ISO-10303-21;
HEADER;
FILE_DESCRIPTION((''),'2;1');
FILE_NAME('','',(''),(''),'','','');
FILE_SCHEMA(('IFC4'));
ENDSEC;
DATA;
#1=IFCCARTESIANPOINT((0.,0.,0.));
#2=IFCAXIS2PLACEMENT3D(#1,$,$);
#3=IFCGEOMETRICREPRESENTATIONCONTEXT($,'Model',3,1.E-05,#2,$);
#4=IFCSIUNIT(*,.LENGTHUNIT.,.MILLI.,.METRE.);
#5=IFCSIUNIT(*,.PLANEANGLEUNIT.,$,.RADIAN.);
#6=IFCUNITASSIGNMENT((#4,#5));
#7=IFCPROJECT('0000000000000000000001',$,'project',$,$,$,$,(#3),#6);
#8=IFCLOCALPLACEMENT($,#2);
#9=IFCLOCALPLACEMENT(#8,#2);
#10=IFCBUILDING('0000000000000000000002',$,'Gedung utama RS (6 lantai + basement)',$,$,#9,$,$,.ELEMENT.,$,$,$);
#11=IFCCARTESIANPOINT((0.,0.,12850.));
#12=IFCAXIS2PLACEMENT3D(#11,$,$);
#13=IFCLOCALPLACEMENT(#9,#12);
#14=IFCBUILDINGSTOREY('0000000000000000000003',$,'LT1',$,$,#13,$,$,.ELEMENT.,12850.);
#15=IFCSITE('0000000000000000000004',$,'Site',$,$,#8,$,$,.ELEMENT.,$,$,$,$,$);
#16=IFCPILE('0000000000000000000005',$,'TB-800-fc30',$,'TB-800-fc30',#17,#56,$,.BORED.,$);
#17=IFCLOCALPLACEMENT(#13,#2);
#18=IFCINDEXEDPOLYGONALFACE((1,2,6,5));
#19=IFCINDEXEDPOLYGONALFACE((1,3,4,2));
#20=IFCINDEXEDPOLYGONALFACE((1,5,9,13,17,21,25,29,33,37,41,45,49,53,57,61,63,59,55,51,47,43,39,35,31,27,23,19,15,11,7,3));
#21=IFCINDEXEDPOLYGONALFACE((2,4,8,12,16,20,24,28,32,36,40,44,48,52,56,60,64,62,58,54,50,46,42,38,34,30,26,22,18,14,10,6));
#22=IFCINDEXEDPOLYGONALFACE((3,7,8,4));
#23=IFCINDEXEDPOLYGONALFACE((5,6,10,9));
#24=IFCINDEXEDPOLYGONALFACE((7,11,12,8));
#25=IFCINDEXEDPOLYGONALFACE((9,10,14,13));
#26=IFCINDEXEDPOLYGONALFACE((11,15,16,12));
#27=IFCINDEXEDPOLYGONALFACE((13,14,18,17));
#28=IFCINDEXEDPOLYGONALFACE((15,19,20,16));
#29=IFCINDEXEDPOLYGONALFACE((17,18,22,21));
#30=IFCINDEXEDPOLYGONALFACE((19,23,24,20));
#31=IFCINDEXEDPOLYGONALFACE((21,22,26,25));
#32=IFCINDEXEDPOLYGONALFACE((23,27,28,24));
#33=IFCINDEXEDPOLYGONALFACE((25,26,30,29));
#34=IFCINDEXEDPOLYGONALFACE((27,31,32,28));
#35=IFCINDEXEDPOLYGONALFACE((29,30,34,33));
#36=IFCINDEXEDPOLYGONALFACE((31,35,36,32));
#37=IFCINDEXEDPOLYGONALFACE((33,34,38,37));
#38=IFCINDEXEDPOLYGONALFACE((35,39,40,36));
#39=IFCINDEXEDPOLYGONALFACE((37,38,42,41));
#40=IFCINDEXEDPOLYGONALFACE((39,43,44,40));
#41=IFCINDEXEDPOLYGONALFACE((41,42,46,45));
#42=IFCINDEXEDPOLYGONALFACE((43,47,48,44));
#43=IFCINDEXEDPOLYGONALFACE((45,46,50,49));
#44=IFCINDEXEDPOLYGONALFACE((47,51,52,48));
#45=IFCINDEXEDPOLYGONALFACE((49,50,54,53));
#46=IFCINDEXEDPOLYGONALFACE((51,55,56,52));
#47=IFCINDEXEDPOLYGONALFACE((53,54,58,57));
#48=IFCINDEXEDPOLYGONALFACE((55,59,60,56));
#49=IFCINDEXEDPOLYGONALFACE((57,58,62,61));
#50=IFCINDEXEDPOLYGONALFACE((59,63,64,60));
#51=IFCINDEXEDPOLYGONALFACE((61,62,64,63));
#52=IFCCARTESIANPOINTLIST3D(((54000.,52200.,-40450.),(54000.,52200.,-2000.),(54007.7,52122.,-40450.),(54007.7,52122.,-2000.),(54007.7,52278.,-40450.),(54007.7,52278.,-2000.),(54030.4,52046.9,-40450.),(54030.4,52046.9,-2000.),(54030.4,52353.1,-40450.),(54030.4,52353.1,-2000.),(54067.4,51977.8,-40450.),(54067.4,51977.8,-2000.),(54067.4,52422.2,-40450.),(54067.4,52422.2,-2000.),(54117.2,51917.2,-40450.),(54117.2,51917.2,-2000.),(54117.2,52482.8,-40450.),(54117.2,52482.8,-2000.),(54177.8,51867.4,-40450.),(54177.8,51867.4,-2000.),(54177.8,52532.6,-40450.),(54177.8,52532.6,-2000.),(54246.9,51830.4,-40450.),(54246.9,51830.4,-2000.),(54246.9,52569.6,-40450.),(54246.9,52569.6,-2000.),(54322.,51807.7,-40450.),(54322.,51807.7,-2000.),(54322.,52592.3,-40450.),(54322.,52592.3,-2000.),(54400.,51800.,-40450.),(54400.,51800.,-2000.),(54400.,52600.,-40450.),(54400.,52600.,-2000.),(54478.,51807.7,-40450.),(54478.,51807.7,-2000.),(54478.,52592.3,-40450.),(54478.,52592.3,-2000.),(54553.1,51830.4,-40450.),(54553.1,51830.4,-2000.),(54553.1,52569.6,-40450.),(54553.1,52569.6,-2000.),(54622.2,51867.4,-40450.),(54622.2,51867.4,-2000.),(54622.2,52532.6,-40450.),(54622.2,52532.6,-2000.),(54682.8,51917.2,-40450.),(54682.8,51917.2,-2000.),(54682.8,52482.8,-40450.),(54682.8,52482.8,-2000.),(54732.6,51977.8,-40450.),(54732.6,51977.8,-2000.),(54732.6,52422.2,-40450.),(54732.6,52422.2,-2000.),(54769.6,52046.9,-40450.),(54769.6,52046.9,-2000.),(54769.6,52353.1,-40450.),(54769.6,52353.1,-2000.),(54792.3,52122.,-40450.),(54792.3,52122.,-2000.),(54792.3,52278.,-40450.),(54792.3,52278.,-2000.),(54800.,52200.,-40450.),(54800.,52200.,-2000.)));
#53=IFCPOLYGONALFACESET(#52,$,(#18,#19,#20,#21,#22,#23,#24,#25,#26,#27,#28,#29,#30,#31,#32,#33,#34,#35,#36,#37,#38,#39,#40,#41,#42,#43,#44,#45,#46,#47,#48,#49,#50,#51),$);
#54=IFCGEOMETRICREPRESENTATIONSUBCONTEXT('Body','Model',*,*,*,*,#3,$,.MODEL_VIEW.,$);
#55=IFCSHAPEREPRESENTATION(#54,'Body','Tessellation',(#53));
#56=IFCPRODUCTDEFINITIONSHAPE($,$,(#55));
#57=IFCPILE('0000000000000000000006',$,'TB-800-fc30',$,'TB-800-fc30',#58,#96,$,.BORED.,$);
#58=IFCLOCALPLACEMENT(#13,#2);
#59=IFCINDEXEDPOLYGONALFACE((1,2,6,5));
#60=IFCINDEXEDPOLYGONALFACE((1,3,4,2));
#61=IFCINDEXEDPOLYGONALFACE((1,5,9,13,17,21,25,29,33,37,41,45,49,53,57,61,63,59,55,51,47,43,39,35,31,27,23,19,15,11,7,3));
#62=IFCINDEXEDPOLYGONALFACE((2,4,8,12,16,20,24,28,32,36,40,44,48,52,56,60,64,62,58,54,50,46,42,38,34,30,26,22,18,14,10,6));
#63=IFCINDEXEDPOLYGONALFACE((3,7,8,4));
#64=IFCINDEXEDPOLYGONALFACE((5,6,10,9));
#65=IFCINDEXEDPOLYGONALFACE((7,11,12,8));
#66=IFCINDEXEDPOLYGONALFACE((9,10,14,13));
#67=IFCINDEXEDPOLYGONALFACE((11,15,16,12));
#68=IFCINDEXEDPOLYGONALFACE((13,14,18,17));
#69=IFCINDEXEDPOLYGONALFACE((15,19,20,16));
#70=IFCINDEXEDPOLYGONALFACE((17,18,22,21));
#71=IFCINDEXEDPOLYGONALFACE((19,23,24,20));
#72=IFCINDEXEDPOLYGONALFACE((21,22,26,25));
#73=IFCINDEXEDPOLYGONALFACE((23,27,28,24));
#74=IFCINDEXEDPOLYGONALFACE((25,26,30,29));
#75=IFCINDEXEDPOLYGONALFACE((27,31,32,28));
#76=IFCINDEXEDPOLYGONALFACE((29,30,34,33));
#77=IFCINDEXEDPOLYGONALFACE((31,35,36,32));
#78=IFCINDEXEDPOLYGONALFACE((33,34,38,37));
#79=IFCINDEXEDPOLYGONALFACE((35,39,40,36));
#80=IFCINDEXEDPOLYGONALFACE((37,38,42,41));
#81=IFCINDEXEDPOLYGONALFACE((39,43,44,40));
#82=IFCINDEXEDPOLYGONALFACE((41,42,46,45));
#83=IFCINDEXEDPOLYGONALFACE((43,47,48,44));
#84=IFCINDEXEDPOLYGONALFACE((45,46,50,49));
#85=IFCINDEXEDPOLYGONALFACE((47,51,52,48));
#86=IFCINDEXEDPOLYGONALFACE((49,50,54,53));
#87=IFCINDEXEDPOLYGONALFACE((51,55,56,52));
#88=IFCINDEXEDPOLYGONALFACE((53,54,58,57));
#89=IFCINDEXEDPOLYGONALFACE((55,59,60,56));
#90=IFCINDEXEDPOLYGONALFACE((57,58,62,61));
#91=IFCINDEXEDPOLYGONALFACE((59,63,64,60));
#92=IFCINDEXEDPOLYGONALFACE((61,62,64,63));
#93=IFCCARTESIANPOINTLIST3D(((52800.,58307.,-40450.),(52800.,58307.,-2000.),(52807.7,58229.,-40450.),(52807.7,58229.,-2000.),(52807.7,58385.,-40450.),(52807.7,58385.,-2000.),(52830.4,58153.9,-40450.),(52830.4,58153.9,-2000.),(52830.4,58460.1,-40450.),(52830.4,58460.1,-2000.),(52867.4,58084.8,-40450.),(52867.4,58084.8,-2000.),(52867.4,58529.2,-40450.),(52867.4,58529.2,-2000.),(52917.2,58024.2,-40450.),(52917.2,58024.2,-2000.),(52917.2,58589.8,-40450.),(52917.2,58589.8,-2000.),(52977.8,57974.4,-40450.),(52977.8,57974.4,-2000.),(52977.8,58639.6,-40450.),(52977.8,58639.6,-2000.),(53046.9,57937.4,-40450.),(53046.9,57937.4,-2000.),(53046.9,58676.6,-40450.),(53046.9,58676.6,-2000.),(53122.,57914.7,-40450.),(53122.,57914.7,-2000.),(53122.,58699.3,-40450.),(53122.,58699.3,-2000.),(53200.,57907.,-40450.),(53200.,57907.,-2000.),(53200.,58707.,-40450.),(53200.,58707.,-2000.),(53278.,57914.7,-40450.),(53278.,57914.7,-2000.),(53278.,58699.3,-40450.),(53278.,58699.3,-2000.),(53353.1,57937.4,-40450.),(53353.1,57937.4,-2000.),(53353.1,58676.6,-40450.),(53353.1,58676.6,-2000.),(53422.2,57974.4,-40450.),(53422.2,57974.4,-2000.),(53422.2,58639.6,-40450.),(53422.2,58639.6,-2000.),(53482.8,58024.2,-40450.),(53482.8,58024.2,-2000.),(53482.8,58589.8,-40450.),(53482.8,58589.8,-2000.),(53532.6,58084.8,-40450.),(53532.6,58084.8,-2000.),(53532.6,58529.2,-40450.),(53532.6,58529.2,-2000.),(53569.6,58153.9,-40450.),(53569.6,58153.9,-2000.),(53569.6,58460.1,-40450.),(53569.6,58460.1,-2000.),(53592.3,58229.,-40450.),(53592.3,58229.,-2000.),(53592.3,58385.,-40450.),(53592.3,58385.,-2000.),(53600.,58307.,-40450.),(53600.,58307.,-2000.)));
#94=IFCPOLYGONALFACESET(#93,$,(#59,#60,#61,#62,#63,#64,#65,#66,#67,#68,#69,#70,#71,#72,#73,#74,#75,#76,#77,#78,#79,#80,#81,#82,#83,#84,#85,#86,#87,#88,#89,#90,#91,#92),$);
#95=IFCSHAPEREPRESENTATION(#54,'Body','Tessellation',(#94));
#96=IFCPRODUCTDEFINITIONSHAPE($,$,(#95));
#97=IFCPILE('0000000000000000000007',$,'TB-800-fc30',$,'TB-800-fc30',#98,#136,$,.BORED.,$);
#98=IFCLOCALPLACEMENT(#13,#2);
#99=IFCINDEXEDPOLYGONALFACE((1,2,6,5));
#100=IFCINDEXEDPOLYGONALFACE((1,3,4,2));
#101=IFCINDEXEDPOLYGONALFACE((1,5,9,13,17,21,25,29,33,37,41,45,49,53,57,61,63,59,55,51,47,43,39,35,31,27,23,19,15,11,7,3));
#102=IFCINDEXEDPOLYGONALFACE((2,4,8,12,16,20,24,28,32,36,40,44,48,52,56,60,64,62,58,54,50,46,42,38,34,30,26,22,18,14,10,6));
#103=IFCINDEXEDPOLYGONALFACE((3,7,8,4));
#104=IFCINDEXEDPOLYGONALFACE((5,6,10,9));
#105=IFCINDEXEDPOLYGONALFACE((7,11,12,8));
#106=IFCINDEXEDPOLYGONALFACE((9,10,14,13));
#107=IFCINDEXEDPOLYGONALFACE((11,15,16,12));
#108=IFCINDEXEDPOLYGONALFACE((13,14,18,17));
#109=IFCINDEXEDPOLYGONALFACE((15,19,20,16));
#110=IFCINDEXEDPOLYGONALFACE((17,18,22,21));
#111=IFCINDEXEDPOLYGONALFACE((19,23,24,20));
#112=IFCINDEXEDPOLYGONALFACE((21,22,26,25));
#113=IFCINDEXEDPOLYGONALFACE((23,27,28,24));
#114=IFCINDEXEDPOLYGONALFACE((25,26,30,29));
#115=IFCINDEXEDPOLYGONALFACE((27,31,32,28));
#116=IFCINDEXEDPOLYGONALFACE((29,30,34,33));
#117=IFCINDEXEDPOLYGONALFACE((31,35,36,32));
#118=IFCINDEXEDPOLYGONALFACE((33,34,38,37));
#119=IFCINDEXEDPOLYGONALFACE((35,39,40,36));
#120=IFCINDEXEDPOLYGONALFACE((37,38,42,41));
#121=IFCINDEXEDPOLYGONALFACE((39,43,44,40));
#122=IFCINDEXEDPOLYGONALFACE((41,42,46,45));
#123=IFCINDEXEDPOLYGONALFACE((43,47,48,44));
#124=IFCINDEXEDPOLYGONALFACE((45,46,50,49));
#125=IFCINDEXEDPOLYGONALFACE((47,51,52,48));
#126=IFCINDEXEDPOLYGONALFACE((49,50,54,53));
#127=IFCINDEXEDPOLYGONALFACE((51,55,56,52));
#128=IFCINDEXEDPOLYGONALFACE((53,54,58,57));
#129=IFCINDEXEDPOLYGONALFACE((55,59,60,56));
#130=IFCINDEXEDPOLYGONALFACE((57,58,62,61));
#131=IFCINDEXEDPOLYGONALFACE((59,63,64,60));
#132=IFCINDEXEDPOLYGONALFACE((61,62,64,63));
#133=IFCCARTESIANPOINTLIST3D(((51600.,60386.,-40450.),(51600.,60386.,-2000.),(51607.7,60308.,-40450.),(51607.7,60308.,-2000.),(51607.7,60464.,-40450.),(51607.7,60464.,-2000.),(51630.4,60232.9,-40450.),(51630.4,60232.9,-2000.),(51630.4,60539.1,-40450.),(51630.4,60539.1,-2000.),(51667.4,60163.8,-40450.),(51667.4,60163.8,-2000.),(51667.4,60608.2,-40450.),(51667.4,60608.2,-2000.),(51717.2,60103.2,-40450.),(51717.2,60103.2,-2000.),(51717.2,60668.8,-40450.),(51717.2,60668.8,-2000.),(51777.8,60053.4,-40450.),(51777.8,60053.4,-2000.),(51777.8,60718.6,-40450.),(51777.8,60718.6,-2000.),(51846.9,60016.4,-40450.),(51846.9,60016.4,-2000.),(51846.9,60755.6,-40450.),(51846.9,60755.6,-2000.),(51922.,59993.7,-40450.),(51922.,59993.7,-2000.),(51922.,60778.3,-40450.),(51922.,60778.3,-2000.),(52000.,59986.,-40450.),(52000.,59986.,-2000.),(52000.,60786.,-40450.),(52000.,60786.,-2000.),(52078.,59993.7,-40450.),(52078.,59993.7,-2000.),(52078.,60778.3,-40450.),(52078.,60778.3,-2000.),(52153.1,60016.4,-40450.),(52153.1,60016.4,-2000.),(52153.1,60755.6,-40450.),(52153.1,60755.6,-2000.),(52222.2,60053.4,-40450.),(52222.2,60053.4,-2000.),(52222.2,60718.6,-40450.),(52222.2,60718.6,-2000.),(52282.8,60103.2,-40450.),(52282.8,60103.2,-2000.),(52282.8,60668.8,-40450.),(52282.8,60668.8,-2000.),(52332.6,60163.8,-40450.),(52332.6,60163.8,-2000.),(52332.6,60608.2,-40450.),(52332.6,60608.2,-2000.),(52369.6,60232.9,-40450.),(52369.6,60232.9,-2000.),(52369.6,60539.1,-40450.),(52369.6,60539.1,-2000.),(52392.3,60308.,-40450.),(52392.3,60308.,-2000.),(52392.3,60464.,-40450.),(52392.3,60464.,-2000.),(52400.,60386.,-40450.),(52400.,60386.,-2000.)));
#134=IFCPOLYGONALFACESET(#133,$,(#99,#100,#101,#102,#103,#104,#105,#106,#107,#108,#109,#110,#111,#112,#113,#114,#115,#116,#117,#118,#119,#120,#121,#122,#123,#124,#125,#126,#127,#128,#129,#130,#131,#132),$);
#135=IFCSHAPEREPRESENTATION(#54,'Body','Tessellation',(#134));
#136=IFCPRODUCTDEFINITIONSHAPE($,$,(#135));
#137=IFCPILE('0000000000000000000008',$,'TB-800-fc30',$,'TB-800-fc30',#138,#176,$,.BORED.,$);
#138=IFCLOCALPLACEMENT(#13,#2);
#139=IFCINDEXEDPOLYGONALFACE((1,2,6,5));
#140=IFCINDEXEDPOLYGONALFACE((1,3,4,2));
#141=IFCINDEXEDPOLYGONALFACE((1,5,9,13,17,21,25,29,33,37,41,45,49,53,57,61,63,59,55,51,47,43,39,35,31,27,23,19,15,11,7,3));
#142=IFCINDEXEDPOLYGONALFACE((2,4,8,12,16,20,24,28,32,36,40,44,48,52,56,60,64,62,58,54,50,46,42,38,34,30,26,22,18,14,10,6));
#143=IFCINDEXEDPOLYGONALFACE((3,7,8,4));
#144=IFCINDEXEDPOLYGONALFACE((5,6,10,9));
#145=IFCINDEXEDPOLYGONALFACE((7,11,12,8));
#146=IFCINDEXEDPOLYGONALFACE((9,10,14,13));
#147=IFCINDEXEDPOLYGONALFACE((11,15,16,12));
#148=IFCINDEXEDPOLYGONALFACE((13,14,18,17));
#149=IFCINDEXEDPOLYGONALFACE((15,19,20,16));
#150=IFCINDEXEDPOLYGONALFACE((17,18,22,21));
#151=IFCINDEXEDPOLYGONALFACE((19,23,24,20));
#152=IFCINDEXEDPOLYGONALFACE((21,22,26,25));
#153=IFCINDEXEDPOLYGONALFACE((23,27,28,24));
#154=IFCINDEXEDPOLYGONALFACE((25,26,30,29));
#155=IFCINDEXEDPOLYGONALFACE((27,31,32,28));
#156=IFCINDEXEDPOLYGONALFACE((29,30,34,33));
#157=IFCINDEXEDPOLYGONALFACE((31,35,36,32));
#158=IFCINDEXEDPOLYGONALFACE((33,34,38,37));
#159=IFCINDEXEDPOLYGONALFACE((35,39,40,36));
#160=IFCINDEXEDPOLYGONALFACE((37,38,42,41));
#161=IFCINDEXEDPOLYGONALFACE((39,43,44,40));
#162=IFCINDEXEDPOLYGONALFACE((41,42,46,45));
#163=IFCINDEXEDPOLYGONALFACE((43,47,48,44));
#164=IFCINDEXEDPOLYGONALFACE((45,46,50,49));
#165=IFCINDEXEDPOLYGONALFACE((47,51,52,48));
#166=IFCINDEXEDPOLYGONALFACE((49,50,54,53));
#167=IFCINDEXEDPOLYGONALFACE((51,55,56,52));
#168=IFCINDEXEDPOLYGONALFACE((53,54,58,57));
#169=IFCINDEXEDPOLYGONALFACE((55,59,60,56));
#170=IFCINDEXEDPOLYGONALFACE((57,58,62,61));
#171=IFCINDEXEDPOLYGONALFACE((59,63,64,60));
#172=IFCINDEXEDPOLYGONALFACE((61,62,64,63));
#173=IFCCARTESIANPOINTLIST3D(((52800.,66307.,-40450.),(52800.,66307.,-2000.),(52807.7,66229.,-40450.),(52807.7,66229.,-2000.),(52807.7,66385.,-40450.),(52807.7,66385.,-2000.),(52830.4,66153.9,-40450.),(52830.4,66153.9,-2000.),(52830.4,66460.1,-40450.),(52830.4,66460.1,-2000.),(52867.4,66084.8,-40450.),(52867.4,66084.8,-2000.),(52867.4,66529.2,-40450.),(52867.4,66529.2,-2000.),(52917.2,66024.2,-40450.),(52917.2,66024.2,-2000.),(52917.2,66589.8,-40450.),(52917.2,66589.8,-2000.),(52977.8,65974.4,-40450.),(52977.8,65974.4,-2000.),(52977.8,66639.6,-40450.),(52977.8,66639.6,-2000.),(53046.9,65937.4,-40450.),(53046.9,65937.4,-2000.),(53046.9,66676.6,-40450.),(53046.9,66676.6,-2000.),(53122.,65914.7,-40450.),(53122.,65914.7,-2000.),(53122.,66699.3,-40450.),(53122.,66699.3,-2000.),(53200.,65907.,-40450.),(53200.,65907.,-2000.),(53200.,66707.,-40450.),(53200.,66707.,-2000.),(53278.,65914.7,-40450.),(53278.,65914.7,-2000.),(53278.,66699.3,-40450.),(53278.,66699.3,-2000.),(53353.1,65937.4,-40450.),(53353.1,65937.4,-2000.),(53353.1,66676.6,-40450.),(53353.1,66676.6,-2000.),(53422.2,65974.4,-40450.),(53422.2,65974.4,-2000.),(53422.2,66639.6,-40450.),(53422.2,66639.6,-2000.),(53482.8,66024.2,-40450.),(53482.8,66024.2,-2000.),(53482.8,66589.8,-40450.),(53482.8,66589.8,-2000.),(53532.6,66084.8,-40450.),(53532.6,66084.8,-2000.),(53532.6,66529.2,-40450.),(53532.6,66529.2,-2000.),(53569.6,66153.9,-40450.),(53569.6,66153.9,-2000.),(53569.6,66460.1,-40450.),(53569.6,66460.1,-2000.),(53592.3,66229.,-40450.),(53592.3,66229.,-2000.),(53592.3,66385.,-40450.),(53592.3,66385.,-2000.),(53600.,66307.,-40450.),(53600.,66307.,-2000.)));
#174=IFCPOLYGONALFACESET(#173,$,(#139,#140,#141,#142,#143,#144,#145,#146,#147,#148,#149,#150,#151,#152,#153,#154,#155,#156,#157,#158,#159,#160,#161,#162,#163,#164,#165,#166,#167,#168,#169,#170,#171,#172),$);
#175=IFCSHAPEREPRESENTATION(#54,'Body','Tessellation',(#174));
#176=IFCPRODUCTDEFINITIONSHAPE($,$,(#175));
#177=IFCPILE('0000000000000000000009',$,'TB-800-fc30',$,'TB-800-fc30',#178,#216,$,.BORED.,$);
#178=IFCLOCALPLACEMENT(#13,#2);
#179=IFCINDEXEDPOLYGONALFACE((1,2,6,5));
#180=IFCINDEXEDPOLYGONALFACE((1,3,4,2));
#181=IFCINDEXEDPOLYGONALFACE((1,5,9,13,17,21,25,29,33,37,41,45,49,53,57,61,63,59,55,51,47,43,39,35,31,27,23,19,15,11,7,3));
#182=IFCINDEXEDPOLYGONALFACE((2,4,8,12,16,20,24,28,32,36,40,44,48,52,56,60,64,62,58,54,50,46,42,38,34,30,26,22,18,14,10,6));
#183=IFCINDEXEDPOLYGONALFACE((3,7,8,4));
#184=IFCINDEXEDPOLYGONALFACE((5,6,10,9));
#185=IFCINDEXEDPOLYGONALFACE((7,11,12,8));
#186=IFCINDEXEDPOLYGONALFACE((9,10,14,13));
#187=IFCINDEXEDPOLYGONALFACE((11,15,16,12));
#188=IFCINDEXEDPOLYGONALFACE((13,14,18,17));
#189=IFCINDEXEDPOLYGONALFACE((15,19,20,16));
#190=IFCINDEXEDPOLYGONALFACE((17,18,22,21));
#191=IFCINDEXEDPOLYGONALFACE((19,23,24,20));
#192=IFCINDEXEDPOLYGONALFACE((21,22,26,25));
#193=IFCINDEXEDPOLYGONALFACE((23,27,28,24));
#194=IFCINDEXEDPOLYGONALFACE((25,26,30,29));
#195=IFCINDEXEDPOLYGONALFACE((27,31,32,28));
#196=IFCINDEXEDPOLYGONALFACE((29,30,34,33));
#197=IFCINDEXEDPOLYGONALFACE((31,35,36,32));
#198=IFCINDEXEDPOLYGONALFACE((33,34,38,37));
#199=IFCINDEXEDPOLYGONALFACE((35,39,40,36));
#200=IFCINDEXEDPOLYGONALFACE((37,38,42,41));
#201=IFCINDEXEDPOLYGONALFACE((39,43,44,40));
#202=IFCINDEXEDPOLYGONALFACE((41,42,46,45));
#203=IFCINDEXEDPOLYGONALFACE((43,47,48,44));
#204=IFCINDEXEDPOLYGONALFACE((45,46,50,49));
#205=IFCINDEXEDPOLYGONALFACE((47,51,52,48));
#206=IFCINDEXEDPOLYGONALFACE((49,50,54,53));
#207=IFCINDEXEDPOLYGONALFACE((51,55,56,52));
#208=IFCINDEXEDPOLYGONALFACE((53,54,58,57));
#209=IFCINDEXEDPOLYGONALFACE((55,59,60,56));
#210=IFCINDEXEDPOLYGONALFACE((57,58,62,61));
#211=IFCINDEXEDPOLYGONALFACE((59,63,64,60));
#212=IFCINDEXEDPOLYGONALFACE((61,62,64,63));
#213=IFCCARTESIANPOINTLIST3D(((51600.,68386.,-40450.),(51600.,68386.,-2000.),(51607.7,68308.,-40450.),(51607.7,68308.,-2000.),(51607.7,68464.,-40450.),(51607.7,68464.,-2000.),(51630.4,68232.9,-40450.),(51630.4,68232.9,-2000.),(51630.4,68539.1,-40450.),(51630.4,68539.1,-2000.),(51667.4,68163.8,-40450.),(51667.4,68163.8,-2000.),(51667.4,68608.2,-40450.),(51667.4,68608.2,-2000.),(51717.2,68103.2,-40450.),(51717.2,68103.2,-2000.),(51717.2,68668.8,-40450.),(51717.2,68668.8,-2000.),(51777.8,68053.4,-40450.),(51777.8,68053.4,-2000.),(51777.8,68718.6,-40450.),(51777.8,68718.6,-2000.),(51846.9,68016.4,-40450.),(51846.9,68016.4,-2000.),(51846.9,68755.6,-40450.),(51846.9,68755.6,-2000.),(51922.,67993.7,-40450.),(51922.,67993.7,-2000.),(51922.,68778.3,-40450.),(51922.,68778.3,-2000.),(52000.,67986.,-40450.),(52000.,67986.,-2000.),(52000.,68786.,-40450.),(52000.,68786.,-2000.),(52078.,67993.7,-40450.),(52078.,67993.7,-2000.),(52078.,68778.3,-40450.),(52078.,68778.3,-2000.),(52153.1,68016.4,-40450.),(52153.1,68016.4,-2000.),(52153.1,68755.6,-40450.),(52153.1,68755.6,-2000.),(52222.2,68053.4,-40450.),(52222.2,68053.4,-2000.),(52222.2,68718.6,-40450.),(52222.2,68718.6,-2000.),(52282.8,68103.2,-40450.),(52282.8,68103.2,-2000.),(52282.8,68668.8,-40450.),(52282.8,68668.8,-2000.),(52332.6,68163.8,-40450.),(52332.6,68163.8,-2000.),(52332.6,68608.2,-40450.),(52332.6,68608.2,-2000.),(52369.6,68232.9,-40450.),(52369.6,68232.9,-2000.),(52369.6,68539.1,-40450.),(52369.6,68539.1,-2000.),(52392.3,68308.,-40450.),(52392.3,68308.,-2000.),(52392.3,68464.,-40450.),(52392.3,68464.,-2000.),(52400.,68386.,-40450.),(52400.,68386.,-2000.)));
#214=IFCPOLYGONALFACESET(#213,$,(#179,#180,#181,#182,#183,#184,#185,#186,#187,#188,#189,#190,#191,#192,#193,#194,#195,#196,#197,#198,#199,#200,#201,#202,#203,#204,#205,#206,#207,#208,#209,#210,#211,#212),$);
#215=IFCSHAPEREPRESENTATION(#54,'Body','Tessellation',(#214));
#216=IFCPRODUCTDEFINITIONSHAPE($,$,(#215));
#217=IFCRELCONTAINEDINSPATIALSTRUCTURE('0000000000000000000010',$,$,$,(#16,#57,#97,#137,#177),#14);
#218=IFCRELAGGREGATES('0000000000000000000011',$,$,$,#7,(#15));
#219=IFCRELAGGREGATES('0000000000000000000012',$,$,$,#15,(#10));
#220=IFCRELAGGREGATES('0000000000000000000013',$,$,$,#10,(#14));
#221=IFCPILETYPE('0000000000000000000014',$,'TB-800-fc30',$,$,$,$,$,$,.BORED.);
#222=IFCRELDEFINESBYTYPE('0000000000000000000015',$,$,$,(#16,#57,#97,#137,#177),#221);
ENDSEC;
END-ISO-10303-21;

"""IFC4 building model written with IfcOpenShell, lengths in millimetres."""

from ifc_helpers import new_model, si_unit, frame, origin, origin_2d, place, context, subcontext, project, spatial, circle, extrude, material_profile, profile_set, profile_usage, type_object, element, save


model = new_model("IFC4")

# Units and contexts
model_context = context("Model", 3, precision=1e-05, world=origin())
body_context = subcontext(model_context, "Body", "Model", "MODEL_VIEW")
ifc_project = project(units=[si_unit("LENGTHUNIT", "METRE", prefix="MILLI"), si_unit("PLANEANGLEUNIT", "RADIAN")], contexts=[model_context])

# Site, building, storey
site_placement = place(None, origin())
site = spatial("IfcSite", under=ifc_project, at=site_placement, Name="Site", CompositionType="ELEMENT")
building_placement = place(site_placement, origin())
building = spatial("IfcBuilding", under=site, at=building_placement, Name="Gedung utama RS (6 lantai + basement)", CompositionType="ELEMENT")
storey_placement = place(building_placement, frame((0.0, 0.0, 12850.0)))
storey = spatial("IfcBuildingStorey", under=building, at=storey_placement, Name="LT1", CompositionType="ELEMENT", Elevation=12850.0)

# Piles
ifc_material_profile_1 = material_profile(None, circle(Radius=400.0, at=origin_2d()), Name="TB-800-fc30")
ifc_profile_set_1 = profile_set([ifc_material_profile_1], Name="TB-800-fc30")
ifc_profile_usage_1 = profile_usage(ifc_profile_set_1, cardinal=5)
pile_type = type_object("IfcPileType", Name="TB-800-fc30", PredefinedType="BORED", material=ifc_profile_set_1)
for number, where, z_axis, x_axis, name in (
    (1, (54400.0, 52200.0, -40450.0), (0.0, 0.0, 1.0), (1.0, 0.0, 0.0), "TB-800-fc30"),
    (2, (53200.0, 58307.0, -40450.0), (0.0, 0.0, 1.0), (1.0, 0.0, 0.0), "TB-800-fc30"),
    (3, (52000.0, 60386.0, -40450.0), (0.0, 0.0, 1.0), (1.0, 0.0, 0.0), "TB-800-fc30"),
    (4, (53200.0, 66307.0, -40450.0), (0.0, 0.0, 1.0), (1.0, 0.0, 0.0), "TB-800-fc30"),
    (5, (52000.0, 68386.0, -40450.0), (0.0, 0.0, 1.0), (1.0, 0.0, 0.0), "TB-800-fc30"),
):
    element("IfcPile", number, at=place(storey_placement, frame(where, z_axis=z_axis, x_axis=x_axis)), inside=storey, type_object=pile_type, material=ifc_profile_usage_1, Name=name, ObjectType="TB-800-fc30", PredefinedType="BORED", context=body_context, shape_type="SweptSolid", body=[
        extrude(circle(Radius=400.0, at=origin_2d()), origin(), (0.0, 0.0, 1.0), 38450.0),
    ])

save(model, "model.ifc")
